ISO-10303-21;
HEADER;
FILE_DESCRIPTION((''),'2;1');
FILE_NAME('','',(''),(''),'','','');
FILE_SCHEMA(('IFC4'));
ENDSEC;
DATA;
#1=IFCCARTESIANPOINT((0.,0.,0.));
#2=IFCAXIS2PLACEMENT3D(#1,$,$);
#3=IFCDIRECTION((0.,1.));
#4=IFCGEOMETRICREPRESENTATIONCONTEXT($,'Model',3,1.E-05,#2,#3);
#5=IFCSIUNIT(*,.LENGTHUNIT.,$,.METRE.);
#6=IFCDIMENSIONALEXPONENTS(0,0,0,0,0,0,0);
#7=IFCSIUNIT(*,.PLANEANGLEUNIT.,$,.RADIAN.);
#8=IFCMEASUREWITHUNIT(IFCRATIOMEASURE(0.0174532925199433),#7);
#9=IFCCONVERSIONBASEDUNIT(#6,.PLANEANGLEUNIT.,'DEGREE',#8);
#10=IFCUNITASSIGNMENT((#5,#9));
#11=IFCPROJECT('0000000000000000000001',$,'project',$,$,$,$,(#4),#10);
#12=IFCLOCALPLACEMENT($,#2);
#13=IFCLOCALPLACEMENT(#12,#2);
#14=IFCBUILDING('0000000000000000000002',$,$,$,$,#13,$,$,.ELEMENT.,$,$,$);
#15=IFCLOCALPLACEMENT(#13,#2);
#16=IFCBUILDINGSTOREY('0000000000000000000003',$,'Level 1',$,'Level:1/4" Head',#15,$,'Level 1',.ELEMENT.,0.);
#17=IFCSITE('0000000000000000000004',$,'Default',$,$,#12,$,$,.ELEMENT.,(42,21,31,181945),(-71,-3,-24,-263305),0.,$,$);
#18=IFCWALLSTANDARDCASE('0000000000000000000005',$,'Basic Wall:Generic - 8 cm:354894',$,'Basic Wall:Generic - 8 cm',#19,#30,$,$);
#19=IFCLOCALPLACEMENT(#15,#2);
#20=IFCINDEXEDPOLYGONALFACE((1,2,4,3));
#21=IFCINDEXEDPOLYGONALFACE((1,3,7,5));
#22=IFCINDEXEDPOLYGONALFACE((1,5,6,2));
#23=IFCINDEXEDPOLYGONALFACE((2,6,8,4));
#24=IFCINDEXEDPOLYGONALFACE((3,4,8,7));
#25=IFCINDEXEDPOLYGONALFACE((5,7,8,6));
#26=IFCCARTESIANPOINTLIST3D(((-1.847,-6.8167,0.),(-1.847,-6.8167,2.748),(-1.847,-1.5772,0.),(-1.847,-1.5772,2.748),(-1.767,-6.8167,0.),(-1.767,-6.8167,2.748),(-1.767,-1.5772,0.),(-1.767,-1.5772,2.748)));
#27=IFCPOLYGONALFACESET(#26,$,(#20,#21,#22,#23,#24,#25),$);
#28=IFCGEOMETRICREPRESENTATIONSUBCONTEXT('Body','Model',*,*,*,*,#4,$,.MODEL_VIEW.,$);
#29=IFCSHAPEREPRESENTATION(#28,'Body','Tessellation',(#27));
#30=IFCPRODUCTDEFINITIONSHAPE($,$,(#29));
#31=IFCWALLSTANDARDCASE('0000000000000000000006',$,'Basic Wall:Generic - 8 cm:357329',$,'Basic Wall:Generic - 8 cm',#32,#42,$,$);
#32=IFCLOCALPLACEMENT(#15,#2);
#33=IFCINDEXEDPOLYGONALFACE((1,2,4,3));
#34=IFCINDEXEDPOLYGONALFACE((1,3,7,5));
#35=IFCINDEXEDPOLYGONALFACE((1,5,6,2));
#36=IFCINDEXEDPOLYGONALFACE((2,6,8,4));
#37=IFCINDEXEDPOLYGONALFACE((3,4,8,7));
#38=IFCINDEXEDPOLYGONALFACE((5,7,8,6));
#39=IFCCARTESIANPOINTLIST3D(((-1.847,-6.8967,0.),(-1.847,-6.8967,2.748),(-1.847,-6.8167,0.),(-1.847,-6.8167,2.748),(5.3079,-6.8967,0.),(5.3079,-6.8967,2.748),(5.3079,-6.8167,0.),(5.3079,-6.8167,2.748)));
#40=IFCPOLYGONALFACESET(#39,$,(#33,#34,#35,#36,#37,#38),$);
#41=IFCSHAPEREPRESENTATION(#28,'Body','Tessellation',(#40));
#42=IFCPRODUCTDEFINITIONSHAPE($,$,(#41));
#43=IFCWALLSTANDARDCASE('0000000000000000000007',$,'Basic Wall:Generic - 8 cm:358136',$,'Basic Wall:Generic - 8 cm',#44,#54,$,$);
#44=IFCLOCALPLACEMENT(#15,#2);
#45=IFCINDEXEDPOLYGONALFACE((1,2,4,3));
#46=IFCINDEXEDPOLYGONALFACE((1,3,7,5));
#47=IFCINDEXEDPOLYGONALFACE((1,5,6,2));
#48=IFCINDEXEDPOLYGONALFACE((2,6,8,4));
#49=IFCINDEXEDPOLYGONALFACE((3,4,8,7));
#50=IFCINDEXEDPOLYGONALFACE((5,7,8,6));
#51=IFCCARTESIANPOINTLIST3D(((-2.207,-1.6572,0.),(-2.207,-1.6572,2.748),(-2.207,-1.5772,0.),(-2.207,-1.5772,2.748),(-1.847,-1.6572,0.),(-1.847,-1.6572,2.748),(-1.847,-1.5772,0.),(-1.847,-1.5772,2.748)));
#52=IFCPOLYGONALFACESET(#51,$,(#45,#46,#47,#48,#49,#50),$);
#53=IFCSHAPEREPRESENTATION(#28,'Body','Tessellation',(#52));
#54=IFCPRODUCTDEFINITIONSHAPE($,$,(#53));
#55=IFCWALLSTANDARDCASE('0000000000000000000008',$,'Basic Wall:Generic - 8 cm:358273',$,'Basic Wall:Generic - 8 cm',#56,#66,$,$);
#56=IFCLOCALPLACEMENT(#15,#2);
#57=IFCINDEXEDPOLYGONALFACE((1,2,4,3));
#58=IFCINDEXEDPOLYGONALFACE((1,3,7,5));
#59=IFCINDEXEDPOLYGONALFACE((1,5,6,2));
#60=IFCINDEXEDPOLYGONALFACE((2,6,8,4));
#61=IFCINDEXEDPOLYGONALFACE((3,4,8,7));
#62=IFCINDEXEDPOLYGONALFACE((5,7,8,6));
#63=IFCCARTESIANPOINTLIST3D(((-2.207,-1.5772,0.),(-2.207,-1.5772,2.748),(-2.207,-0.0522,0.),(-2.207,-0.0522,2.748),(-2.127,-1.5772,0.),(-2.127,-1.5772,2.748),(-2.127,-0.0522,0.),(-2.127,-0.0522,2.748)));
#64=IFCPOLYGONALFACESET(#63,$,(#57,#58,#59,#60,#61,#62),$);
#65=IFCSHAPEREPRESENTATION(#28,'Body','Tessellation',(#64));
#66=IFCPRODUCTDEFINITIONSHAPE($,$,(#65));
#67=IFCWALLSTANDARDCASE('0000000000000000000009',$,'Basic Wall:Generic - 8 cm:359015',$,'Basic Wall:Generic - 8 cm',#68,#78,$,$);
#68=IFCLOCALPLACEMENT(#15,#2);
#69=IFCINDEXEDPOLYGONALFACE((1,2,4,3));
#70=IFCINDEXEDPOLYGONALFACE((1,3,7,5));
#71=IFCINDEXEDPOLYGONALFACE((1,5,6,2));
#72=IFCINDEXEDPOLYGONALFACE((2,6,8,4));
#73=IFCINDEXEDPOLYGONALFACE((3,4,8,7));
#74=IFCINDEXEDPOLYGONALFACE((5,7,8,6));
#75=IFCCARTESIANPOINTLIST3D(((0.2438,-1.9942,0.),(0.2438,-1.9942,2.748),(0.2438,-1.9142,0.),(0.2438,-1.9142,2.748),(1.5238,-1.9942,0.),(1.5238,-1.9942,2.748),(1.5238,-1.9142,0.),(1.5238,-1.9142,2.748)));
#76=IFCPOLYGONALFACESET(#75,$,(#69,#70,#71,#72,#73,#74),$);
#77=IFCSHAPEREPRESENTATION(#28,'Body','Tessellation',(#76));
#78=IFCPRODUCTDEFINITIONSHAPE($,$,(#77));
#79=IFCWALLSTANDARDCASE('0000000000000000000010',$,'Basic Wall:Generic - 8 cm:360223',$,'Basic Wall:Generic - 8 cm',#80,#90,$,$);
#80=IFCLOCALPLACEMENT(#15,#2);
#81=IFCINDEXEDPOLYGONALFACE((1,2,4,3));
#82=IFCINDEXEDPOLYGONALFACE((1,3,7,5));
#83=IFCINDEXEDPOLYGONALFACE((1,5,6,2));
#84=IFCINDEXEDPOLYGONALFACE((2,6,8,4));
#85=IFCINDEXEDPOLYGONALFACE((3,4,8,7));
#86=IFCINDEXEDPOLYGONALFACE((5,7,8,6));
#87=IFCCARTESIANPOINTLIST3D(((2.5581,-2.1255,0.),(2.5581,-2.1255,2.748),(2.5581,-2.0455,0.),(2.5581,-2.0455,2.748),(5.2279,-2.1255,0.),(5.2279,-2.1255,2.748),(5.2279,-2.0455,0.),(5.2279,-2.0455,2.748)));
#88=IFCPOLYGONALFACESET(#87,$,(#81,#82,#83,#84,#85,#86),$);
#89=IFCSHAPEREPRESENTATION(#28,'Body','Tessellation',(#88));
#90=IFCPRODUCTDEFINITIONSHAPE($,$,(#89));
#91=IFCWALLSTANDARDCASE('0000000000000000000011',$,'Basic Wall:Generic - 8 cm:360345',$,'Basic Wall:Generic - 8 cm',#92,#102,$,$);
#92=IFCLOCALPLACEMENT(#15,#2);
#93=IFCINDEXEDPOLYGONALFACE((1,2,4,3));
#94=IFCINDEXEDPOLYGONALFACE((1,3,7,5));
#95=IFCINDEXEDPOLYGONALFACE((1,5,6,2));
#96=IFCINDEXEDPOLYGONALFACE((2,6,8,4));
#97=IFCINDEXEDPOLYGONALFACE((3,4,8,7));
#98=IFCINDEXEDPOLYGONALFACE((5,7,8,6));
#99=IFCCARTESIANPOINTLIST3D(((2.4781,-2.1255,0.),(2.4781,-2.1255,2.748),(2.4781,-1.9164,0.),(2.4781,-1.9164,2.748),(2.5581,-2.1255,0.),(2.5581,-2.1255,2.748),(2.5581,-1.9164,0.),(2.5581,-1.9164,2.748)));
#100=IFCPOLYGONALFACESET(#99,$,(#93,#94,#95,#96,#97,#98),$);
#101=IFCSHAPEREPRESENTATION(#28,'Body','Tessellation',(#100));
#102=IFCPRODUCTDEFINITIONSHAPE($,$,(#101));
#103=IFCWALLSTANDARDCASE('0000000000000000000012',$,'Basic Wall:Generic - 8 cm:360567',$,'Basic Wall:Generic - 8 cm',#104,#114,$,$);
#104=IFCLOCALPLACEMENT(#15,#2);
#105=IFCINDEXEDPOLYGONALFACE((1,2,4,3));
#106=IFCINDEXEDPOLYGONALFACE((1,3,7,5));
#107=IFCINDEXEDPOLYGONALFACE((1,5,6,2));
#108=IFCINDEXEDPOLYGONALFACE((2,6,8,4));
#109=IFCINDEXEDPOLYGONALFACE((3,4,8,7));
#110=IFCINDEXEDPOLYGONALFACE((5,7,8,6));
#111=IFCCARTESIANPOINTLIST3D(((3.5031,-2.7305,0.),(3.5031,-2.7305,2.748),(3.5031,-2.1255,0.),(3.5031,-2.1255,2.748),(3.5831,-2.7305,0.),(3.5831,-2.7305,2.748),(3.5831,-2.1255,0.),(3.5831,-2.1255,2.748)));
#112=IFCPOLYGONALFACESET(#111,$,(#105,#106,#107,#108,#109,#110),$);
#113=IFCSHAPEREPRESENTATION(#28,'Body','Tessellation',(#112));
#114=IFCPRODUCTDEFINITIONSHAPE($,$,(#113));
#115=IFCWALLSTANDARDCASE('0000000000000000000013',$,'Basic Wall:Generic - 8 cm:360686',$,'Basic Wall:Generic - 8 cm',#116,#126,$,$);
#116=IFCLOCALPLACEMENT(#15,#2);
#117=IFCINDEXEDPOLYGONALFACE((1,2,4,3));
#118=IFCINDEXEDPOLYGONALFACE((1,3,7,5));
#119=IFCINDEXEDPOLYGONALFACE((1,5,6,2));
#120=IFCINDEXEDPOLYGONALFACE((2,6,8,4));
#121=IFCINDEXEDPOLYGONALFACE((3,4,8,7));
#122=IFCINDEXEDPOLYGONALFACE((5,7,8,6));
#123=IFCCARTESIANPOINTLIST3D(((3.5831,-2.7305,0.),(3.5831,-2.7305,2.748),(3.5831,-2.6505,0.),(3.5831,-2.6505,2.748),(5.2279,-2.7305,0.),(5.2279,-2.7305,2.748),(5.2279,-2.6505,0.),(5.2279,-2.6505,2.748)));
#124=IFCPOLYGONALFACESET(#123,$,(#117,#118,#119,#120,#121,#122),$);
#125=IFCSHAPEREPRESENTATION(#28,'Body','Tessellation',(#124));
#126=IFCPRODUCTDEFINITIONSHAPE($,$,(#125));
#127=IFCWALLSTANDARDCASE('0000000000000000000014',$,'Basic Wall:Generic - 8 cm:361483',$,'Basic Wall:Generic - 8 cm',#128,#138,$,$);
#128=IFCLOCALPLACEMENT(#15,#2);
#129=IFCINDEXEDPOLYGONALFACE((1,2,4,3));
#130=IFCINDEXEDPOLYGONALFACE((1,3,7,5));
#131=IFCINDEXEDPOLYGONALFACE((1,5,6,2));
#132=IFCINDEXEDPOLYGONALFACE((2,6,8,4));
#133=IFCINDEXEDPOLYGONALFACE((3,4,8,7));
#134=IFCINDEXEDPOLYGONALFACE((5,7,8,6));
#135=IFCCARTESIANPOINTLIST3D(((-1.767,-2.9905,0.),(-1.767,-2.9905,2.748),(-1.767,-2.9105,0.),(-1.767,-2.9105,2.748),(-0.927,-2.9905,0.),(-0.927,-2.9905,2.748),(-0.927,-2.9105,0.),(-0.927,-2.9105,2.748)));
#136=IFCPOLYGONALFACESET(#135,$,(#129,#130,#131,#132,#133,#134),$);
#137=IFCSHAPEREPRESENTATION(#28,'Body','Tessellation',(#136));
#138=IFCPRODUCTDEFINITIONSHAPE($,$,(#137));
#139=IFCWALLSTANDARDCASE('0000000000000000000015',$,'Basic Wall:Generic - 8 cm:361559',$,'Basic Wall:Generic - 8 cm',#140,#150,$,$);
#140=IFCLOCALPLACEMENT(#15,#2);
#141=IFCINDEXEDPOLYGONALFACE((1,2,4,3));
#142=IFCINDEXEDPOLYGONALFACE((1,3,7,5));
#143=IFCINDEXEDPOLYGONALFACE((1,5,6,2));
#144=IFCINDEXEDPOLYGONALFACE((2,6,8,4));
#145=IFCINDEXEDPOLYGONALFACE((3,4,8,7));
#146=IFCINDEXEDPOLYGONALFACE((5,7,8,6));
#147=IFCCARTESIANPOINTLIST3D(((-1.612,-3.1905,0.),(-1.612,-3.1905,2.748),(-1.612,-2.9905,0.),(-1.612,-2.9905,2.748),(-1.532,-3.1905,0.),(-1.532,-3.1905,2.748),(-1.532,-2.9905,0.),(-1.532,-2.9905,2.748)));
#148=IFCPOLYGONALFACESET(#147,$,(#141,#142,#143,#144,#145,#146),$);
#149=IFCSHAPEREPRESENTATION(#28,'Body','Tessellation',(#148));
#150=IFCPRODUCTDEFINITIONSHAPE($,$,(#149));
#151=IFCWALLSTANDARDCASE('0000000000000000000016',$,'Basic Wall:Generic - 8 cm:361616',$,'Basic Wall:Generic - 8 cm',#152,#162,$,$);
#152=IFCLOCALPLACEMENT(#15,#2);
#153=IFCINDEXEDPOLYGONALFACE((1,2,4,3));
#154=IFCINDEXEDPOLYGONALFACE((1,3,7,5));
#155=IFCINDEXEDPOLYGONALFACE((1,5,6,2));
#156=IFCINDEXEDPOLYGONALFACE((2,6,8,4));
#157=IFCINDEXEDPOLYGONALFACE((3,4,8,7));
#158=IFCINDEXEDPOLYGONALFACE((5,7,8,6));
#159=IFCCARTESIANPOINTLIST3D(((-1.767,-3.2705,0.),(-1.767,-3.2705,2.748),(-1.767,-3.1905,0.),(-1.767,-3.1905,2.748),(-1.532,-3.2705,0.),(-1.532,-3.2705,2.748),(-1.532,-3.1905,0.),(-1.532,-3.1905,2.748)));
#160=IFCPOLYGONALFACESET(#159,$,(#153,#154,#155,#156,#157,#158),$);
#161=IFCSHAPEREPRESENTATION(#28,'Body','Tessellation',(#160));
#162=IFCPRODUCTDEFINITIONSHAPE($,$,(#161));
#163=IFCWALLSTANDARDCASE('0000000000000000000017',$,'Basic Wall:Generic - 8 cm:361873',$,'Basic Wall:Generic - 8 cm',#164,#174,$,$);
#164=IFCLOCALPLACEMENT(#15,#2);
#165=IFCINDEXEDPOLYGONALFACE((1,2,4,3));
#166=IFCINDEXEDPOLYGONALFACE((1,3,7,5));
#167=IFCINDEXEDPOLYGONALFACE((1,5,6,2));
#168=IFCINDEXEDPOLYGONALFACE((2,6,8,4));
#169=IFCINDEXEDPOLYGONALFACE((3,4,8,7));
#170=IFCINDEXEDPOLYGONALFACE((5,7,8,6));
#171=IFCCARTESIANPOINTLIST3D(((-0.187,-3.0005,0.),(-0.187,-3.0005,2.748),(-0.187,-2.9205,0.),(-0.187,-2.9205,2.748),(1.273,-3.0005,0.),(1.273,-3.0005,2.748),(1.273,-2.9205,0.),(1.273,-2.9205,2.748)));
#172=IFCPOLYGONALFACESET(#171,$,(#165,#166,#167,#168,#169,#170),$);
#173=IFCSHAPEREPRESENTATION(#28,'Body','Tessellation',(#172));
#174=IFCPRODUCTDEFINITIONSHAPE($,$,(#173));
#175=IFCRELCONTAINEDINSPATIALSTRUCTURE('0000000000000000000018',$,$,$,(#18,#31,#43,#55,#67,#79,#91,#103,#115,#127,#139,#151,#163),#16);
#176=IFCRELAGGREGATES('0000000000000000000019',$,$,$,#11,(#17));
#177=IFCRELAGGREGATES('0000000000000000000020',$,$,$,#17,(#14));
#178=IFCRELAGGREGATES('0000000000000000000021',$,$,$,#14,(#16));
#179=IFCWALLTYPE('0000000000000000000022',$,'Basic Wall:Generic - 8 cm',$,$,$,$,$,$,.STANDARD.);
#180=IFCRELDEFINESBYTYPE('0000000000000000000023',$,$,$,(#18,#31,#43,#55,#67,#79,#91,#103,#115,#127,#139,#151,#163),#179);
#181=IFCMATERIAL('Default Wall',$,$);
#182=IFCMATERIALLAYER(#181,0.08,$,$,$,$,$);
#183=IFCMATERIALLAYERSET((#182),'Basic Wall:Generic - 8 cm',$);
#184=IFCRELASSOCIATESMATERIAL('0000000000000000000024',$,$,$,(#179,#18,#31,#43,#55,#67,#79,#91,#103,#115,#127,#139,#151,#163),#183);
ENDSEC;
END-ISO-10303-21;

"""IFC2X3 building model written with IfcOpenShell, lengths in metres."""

from ifc_helpers import new_model, entity, si_unit, converted_unit, direction, frame, frame_2d, origin, place, context, subcontext, project, spatial, rectangle, extrude, material, layer, layer_set, layer_usage, type_object, element, save


model = new_model("IFC2X3")

# Units and contexts
model_context = context("Model", 3, precision=1e-05, world=origin(), true_north=direction((0.0, 1.0)))
body_context = subcontext(model_context, "Body", "Model", "MODEL_VIEW")
ifc_project = project(units=[si_unit("LENGTHUNIT", "METRE"), converted_unit("PLANEANGLEUNIT", "DEGREE", entity("IfcRatioMeasure", 0.0174532925199433), si_unit("PLANEANGLEUNIT", "RADIAN"), dimensions=[0, 0, 0, 0, 0, 0, 0])], contexts=[model_context])

# Site, building, storey
site_placement = place(None, origin())
site = spatial("IfcSite", under=ifc_project, at=site_placement, Name="Default", CompositionType="ELEMENT", RefLatitude=(42, 21, 31, 181945), RefLongitude=(-71, -3, -24, -263305), RefElevation=0.0)
building_placement = place(site_placement, origin())
building = spatial("IfcBuilding", under=site, at=building_placement, CompositionType="ELEMENT")
storey_placement = place(building_placement, origin())
storey = spatial("IfcBuildingStorey", under=building, at=storey_placement, Name="Level 1", ObjectType="Level:1/4\" Head", LongName="Level 1", CompositionType="ELEMENT", Elevation=0.0)

# Walls
ifc_material = material(Name="Default Wall")
ifc_layer = layer(ifc_material, 0.08)
ifc_layer_set = layer_set([ifc_layer], Name="Basic Wall:Generic - 8 cm")
ifc_layer_usage_1 = layer_usage(ifc_layer_set, "AXIS2", "NEGATIVE", 0.04)
wall_type = type_object("IfcWallType", Name="Basic Wall:Generic - 8 cm", PredefinedType="STANDARD", material=ifc_layer_set)
wall_1_placement = place(storey_placement, frame((-1.807, -6.8167, 0.0), z_axis=(0.0, 0.0, 1.0), x_axis=(0.0, 1.0, 0.0)))
element("IfcWallStandardCase", 1, at=wall_1_placement, inside=storey, type_object=wall_type, material=ifc_layer_usage_1, Name="Basic Wall:Generic - 8 cm:354894", ObjectType="Basic Wall:Generic - 8 cm", context=body_context, shape_type="SweptSolid", body=[
    extrude(rectangle(XDim=5.2395, YDim=0.08, at=frame_2d((2.6198, 0.0), x_axis=(-1.0, 0.0))), origin(), (0.0, 0.0, 1.0), 2.748),
])
ifc_layer_usage_2 = layer_usage(ifc_layer_set, "AXIS2", "NEGATIVE", 0.04)
wall_2_placement = place(storey_placement, frame((5.3079, -6.8567, 0.0), z_axis=(0.0, 0.0, 1.0), x_axis=(-1.0, 0.0, 0.0)))
element("IfcWallStandardCase", 2, at=wall_2_placement, inside=storey, type_object=wall_type, material=ifc_layer_usage_2, Name="Basic Wall:Generic - 8 cm:357329", ObjectType="Basic Wall:Generic - 8 cm", context=body_context, shape_type="SweptSolid", body=[
    extrude(rectangle(XDim=7.1549, YDim=0.08, at=frame_2d((3.5774, 0.0), x_axis=(-1.0, 0.0))), origin(), (0.0, 0.0, 1.0), 2.748),
])
ifc_layer_usage_3 = layer_usage(ifc_layer_set, "AXIS2", "NEGATIVE", 0.04)
wall_3_placement = place(storey_placement, frame((-1.847, -1.6172, 0.0), z_axis=(0.0, 0.0, 1.0), x_axis=(-1.0, 0.0, 0.0)))
element("IfcWallStandardCase", 3, at=wall_3_placement, inside=storey, type_object=wall_type, material=ifc_layer_usage_3, Name="Basic Wall:Generic - 8 cm:358136", ObjectType="Basic Wall:Generic - 8 cm", context=body_context, shape_type="SweptSolid", body=[
    extrude(rectangle(XDim=0.36, YDim=0.08, at=frame_2d((0.18, 0.0), x_axis=(-1.0, 0.0))), origin(), (0.0, 0.0, 1.0), 2.748),
])
ifc_layer_usage_4 = layer_usage(ifc_layer_set, "AXIS2", "NEGATIVE", 0.04)
wall_4_placement = place(storey_placement, frame((-2.167, -1.5772, 0.0), z_axis=(0.0, 0.0, 1.0), x_axis=(0.0, 1.0, 0.0)))
element("IfcWallStandardCase", 4, at=wall_4_placement, inside=storey, type_object=wall_type, material=ifc_layer_usage_4, Name="Basic Wall:Generic - 8 cm:358273", ObjectType="Basic Wall:Generic - 8 cm", context=body_context, shape_type="SweptSolid", body=[
    extrude(rectangle(XDim=1.525, YDim=0.08, at=frame_2d((0.7625, 0.0), x_axis=(-1.0, 0.0))), origin(), (0.0, 0.0, 1.0), 2.748),
])
ifc_layer_usage_5 = layer_usage(ifc_layer_set, "AXIS2", "NEGATIVE", 0.04)
wall_5_placement = place(storey_placement, frame((1.5238, -1.9542, 0.0), z_axis=(0.0, 0.0, 1.0), x_axis=(-1.0, 0.0, 0.0)))
element("IfcWallStandardCase", 5, at=wall_5_placement, inside=storey, type_object=wall_type, material=ifc_layer_usage_5, Name="Basic Wall:Generic - 8 cm:359015", ObjectType="Basic Wall:Generic - 8 cm", context=body_context, shape_type="SweptSolid", body=[
    extrude(rectangle(XDim=1.28, YDim=0.08, at=frame_2d((0.64, 0.0), x_axis=(-1.0, 0.0))), origin(), (0.0, 0.0, 1.0), 2.748),
])
ifc_layer_usage_6 = layer_usage(ifc_layer_set, "AXIS2", "NEGATIVE", 0.04)
wall_6_placement = place(storey_placement, frame((2.5581, -2.0855, 0.0)))
element("IfcWallStandardCase", 6, at=wall_6_placement, inside=storey, type_object=wall_type, material=ifc_layer_usage_6, Name="Basic Wall:Generic - 8 cm:360223", ObjectType="Basic Wall:Generic - 8 cm", context=body_context, shape_type="SweptSolid", body=[
    extrude(rectangle(XDim=2.6698, YDim=0.08, at=frame_2d((1.3349, 0.0), x_axis=(-1.0, 0.0))), origin(), (0.0, 0.0, 1.0), 2.748),
])
ifc_layer_usage_7 = layer_usage(ifc_layer_set, "AXIS2", "NEGATIVE", 0.04)
wall_7_placement = place(storey_placement, frame((2.5181, -1.9164, 0.0), z_axis=(0.0, 0.0, 1.0), x_axis=(0.0, -1.0, 0.0)))
element("IfcWallStandardCase", 7, at=wall_7_placement, inside=storey, type_object=wall_type, material=ifc_layer_usage_7, Name="Basic Wall:Generic - 8 cm:360345", ObjectType="Basic Wall:Generic - 8 cm", context=body_context, shape_type="SweptSolid", body=[
    extrude(rectangle(XDim=0.2091, YDim=0.08, at=frame_2d((0.1045, 0.0), x_axis=(-1.0, 0.0))), origin(), (0.0, 0.0, 1.0), 2.748),
])
ifc_layer_usage_8 = layer_usage(ifc_layer_set, "AXIS2", "NEGATIVE", 0.04)
wall_8_placement = place(storey_placement, frame((3.5431, -2.1255, 0.0), z_axis=(0.0, 0.0, 1.0), x_axis=(0.0, -1.0, 0.0)))
element("IfcWallStandardCase", 8, at=wall_8_placement, inside=storey, type_object=wall_type, material=ifc_layer_usage_8, Name="Basic Wall:Generic - 8 cm:360567", ObjectType="Basic Wall:Generic - 8 cm", context=body_context, shape_type="SweptSolid", body=[
    extrude(rectangle(XDim=0.605, YDim=0.08, at=frame_2d((0.3025, 0.0), x_axis=(-1.0, 0.0))), origin(), (0.0, 0.0, 1.0), 2.748),
])
ifc_layer_usage_9 = layer_usage(ifc_layer_set, "AXIS2", "NEGATIVE", 0.04)
wall_9_placement = place(storey_placement, frame((3.5831, -2.6905, 0.0)))
element("IfcWallStandardCase", 9, at=wall_9_placement, inside=storey, type_object=wall_type, material=ifc_layer_usage_9, Name="Basic Wall:Generic - 8 cm:360686", ObjectType="Basic Wall:Generic - 8 cm", context=body_context, shape_type="SweptSolid", body=[
    extrude(rectangle(XDim=1.6448, YDim=0.08, at=frame_2d((0.8224, 0.0), x_axis=(-1.0, 0.0))), origin(), (0.0, 0.0, 1.0), 2.748),
])
ifc_layer_usage_10 = layer_usage(ifc_layer_set, "AXIS2", "NEGATIVE", 0.04)
wall_10_placement = place(storey_placement, frame((-1.767, -2.9505, 0.0)))
element("IfcWallStandardCase", 10, at=wall_10_placement, inside=storey, type_object=wall_type, material=ifc_layer_usage_10, Name="Basic Wall:Generic - 8 cm:361483", ObjectType="Basic Wall:Generic - 8 cm", context=body_context, shape_type="SweptSolid", body=[
    extrude(rectangle(XDim=0.84, YDim=0.08, at=frame_2d((0.42, 0.0), x_axis=(-1.0, 0.0))), origin(), (0.0, 0.0, 1.0), 2.748),
])
ifc_layer_usage_11 = layer_usage(ifc_layer_set, "AXIS2", "NEGATIVE", 0.04)
wall_11_placement = place(storey_placement, frame((-1.572, -2.9905, 0.0), z_axis=(0.0, 0.0, 1.0), x_axis=(0.0, -1.0, 0.0)))
element("IfcWallStandardCase", 11, at=wall_11_placement, inside=storey, type_object=wall_type, material=ifc_layer_usage_11, Name="Basic Wall:Generic - 8 cm:361559", ObjectType="Basic Wall:Generic - 8 cm", context=body_context, shape_type="SweptSolid", body=[
    extrude(rectangle(XDim=0.2, YDim=0.08, at=frame_2d((0.1, 0.0), x_axis=(-1.0, 0.0))), origin(), (0.0, 0.0, 1.0), 2.748),
])
ifc_layer_usage_12 = layer_usage(ifc_layer_set, "AXIS2", "NEGATIVE", 0.04)
wall_12_placement = place(storey_placement, frame((-1.532, -3.2305, 0.0), z_axis=(0.0, 0.0, 1.0), x_axis=(-1.0, 0.0, 0.0)))
element("IfcWallStandardCase", 12, at=wall_12_placement, inside=storey, type_object=wall_type, material=ifc_layer_usage_12, Name="Basic Wall:Generic - 8 cm:361616", ObjectType="Basic Wall:Generic - 8 cm", context=body_context, shape_type="SweptSolid", body=[
    extrude(rectangle(XDim=0.235, YDim=0.08, at=frame_2d((0.1175, 0.0), x_axis=(-1.0, 0.0))), origin(), (0.0, 0.0, 1.0), 2.748),
])
ifc_layer_usage_13 = layer_usage(ifc_layer_set, "AXIS2", "NEGATIVE", 0.04)
wall_13_placement = place(storey_placement, frame((-0.187, -2.9605, 0.0)))
element("IfcWallStandardCase", 13, at=wall_13_placement, inside=storey, type_object=wall_type, material=ifc_layer_usage_13, Name="Basic Wall:Generic - 8 cm:361873", ObjectType="Basic Wall:Generic - 8 cm", context=body_context, shape_type="SweptSolid", body=[
    extrude(rectangle(XDim=1.4599, YDim=0.08, at=frame_2d((0.73, 0.0), x_axis=(-1.0, 0.0))), origin(), (0.0, 0.0, 1.0), 2.748),
])

save(model, "model.ifc")
